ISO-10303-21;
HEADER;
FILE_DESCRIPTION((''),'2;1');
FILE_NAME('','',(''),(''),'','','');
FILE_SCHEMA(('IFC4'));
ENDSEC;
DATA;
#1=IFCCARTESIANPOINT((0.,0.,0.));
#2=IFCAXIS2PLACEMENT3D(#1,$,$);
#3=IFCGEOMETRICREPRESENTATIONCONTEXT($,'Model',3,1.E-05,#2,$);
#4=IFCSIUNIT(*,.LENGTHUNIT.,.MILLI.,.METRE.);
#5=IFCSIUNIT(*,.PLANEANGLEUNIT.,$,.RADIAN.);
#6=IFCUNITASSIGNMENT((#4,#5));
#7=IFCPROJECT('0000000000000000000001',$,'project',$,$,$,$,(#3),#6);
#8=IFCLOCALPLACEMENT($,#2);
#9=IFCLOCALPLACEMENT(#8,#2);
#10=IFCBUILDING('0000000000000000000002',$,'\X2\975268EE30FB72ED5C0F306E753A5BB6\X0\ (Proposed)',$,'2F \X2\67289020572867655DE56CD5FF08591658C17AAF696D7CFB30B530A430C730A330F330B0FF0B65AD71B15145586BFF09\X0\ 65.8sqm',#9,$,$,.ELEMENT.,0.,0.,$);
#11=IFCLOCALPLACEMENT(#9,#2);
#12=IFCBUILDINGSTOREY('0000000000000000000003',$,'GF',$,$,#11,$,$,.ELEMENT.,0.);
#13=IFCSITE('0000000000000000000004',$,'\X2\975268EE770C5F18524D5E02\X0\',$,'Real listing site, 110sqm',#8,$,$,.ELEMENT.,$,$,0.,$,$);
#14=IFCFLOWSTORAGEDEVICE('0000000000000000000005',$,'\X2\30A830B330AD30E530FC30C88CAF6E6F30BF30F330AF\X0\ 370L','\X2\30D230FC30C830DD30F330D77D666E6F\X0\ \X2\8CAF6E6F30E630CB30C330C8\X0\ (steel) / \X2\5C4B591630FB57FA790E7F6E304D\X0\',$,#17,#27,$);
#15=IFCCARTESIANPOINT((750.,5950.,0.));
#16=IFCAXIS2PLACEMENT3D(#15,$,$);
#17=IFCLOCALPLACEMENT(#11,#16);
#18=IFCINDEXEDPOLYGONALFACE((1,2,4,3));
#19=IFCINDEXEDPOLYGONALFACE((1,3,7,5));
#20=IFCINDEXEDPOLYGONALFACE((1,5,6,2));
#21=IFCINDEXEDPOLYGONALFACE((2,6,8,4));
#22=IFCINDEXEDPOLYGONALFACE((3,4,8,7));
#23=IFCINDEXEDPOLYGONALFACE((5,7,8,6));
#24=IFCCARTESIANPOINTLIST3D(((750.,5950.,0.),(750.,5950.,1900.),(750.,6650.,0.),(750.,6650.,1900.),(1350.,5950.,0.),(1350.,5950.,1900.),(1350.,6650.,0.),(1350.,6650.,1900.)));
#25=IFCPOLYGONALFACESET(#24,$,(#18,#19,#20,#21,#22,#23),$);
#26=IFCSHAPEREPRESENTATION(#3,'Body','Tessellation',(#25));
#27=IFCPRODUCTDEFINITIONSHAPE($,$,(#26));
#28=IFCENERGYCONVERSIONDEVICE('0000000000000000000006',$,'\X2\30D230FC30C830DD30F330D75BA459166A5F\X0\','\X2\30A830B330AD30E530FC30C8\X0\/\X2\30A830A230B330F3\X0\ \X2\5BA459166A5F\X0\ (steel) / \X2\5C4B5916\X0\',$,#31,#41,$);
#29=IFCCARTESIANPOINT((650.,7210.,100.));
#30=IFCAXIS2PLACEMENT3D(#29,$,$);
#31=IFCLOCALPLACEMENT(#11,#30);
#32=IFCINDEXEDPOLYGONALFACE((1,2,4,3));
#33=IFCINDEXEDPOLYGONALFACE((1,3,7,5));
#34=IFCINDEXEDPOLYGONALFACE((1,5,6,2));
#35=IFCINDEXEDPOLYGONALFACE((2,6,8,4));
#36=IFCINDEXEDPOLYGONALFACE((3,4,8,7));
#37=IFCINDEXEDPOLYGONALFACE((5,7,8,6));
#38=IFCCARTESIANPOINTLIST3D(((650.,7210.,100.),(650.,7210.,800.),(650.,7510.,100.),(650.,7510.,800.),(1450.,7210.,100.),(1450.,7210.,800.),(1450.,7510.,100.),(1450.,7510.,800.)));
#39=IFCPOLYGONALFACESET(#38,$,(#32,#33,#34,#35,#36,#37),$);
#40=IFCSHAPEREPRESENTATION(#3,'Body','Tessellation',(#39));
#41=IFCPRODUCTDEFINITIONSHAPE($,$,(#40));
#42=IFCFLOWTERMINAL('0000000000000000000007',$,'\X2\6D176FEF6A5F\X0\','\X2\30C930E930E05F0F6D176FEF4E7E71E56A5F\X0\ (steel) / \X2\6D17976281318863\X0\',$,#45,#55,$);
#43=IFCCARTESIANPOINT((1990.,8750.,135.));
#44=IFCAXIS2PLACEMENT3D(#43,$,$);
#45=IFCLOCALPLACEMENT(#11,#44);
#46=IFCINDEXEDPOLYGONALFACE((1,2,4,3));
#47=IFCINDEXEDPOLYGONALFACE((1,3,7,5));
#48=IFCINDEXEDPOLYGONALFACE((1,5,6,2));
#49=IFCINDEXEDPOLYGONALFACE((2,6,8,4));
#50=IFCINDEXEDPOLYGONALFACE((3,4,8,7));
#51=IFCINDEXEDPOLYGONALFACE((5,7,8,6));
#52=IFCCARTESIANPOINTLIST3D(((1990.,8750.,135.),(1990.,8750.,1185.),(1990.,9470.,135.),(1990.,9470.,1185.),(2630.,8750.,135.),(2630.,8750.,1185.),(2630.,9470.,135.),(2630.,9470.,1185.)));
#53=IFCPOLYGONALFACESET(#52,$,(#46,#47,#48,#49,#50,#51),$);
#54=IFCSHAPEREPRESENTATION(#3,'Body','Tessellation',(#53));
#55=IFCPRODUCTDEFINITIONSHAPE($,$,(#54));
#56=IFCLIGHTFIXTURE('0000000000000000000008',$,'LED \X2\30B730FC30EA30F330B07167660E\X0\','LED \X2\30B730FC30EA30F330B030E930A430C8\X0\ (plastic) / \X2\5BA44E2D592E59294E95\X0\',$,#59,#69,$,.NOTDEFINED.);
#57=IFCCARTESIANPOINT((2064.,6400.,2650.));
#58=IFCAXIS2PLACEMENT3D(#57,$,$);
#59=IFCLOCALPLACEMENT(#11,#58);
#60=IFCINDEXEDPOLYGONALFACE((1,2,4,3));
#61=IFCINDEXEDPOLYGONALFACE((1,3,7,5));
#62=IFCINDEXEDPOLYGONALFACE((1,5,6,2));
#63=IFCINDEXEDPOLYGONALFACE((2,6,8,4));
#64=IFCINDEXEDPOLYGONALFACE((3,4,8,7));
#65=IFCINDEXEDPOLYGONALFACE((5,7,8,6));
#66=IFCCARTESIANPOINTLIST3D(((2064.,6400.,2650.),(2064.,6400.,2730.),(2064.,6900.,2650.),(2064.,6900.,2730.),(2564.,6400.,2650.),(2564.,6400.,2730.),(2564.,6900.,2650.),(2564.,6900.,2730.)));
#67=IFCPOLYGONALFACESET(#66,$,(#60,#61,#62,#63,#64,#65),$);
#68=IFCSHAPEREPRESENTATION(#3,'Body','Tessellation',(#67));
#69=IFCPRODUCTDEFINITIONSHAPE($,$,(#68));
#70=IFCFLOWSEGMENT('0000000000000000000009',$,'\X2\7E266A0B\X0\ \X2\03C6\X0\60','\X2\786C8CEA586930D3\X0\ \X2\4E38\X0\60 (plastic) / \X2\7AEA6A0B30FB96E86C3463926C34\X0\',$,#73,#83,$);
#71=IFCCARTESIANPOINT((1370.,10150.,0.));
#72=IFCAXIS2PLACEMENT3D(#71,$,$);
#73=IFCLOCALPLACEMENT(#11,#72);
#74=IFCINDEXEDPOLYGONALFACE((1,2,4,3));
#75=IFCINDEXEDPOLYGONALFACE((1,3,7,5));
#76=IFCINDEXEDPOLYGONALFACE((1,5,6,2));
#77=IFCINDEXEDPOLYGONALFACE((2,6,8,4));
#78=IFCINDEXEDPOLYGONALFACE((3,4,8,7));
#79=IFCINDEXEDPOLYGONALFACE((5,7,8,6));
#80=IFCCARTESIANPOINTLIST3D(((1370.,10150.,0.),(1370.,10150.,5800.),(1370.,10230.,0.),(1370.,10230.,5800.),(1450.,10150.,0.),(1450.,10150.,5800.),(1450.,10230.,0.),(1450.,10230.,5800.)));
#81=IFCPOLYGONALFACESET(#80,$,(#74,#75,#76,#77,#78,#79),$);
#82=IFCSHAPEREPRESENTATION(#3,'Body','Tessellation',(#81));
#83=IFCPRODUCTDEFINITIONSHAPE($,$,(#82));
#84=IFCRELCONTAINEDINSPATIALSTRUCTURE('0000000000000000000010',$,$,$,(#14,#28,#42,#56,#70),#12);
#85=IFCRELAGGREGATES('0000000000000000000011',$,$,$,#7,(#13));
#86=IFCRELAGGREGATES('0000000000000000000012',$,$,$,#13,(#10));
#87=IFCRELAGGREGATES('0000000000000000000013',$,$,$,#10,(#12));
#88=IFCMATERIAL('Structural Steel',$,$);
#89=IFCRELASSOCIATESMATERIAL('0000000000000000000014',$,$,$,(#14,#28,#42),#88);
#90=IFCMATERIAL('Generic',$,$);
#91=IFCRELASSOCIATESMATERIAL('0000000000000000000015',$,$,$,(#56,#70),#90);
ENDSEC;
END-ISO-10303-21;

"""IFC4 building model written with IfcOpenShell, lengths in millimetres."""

from ifc_helpers import new_model, si_unit, frame, frame_2d, origin, place, context, project, spatial, rectangle, extrude, material, element, save


model = new_model("IFC4")

# Units and contexts
model_context = context("Model", 3, precision=1e-05, world=origin())
ifc_project = project(units=[si_unit("LENGTHUNIT", "METRE", prefix="MILLI"), si_unit("PLANEANGLEUNIT", "RADIAN")], contexts=[model_context])

# Site, building, storey
site_placement = place(None, origin())
site = spatial("IfcSite", under=ifc_project, at=site_placement, Name="青森県弘前市", ObjectType="Real listing site, 110sqm", CompositionType="ELEMENT", RefElevation=0.0)
building_placement = place(site_placement, origin())
building = spatial("IfcBuilding", under=site, at=building_placement, Name="青森・狭小の町家 (Proposed)", ObjectType="2F 木造在来工法（外壁窯業系サイディング＋断熱充填） 65.8sqm", CompositionType="ELEMENT", ElevationOfRefHeight=0.0, ElevationOfTerrain=0.0)
storey_placement = place(building_placement, origin())
storey = spatial("IfcBuildingStorey", under=building, at=storey_placement, Name="GF", CompositionType="ELEMENT", Elevation=0.0)

# Shared definitions
ifc_material_1 = material(Name="Generic")

# Flow storage device
ifc_material_2 = material(Name="Structural Steel")
flow_storage_device_placement = place(storey_placement, frame((750.0, 5950.0, 0.0)))
element("IfcFlowStorageDevice", 1, at=flow_storage_device_placement, inside=storey, material=ifc_material_2, Name="エコキュート貯湯タンク 370L", Description="ヒートポンプ給湯 貯湯ユニット (steel) / 屋外・基礎置き", context=model_context, shape_type="SweptSolid", body=[
    extrude(rectangle(XDim=600.0, YDim=700.0, at=frame_2d((300.0, 350.0))), frame((750.0, 5950.0, 0.0)), (0.0, 0.0, 1.0), 1900.0),
])

# Energy conversion device
energy_conversion_device_placement = place(storey_placement, frame((650.0, 7210.0, 100.0)))
element("IfcEnergyConversionDevice", 2, at=energy_conversion_device_placement, inside=storey, material=ifc_material_2, Name="ヒートポンプ室外機", Description="エコキュート/エアコン 室外機 (steel) / 屋外", context=model_context, shape_type="SweptSolid", body=[
    extrude(rectangle(XDim=800.0, YDim=300.0, at=frame_2d((400.0, 150.0))), frame((650.0, 7210.0, 100.0)), (0.0, 0.0, 1.0), 700.0),
])

# Flow terminal
flow_terminal_placement = place(storey_placement, frame((1990.0, 8750.0, 135.0)))
element("IfcFlowTerminal", 3, at=flow_terminal_placement, inside=storey, material=ifc_material_2, Name="洗濯機", Description="ドラム式洗濯乾燥機 (steel) / 洗面脱衣", context=model_context, shape_type="SweptSolid", body=[
    extrude(rectangle(XDim=640.0, YDim=720.0, at=frame_2d((320.0, 360.0))), frame((1990.0, 8750.0, 135.0)), (0.0, 0.0, 1.0), 1050.0),
])

# Light fixture
light_fixture_placement = place(storey_placement, frame((2064.0, 6400.0, 2650.0)))
element("IfcLightFixture", 4, at=light_fixture_placement, inside=storey, material=ifc_material_1, Name="LED シーリング照明", Description="LED シーリングライト (plastic) / 室中央天井", PredefinedType="NOTDEFINED", context=model_context, shape_type="SweptSolid", body=[
    extrude(rectangle(XDim=500.0, YDim=500.0, at=frame_2d((250.0, 250.0))), frame((2064.0, 6400.0, 2650.0)), (0.0, 0.0, 1.0), 80.0),
])

# Flow segment
flow_segment_placement = place(storey_placement, frame((1370.0, 10150.0, 0.0)))
element("IfcFlowSegment", 5, at=flow_segment_placement, inside=storey, material=ifc_material_1, Name="縦樋 φ60", Description="硬質塩ビ 丸60 (plastic) / 竪樋・雨水排水", context=model_context, shape_type="SweptSolid", body=[
    extrude(rectangle(XDim=80.0, YDim=80.0, at=frame_2d((40.0, 40.0))), frame((1370.0, 10150.0, 0.0)), (0.0, 0.0, 1.0), 5800.0),
])

save(model, "model.ifc")
